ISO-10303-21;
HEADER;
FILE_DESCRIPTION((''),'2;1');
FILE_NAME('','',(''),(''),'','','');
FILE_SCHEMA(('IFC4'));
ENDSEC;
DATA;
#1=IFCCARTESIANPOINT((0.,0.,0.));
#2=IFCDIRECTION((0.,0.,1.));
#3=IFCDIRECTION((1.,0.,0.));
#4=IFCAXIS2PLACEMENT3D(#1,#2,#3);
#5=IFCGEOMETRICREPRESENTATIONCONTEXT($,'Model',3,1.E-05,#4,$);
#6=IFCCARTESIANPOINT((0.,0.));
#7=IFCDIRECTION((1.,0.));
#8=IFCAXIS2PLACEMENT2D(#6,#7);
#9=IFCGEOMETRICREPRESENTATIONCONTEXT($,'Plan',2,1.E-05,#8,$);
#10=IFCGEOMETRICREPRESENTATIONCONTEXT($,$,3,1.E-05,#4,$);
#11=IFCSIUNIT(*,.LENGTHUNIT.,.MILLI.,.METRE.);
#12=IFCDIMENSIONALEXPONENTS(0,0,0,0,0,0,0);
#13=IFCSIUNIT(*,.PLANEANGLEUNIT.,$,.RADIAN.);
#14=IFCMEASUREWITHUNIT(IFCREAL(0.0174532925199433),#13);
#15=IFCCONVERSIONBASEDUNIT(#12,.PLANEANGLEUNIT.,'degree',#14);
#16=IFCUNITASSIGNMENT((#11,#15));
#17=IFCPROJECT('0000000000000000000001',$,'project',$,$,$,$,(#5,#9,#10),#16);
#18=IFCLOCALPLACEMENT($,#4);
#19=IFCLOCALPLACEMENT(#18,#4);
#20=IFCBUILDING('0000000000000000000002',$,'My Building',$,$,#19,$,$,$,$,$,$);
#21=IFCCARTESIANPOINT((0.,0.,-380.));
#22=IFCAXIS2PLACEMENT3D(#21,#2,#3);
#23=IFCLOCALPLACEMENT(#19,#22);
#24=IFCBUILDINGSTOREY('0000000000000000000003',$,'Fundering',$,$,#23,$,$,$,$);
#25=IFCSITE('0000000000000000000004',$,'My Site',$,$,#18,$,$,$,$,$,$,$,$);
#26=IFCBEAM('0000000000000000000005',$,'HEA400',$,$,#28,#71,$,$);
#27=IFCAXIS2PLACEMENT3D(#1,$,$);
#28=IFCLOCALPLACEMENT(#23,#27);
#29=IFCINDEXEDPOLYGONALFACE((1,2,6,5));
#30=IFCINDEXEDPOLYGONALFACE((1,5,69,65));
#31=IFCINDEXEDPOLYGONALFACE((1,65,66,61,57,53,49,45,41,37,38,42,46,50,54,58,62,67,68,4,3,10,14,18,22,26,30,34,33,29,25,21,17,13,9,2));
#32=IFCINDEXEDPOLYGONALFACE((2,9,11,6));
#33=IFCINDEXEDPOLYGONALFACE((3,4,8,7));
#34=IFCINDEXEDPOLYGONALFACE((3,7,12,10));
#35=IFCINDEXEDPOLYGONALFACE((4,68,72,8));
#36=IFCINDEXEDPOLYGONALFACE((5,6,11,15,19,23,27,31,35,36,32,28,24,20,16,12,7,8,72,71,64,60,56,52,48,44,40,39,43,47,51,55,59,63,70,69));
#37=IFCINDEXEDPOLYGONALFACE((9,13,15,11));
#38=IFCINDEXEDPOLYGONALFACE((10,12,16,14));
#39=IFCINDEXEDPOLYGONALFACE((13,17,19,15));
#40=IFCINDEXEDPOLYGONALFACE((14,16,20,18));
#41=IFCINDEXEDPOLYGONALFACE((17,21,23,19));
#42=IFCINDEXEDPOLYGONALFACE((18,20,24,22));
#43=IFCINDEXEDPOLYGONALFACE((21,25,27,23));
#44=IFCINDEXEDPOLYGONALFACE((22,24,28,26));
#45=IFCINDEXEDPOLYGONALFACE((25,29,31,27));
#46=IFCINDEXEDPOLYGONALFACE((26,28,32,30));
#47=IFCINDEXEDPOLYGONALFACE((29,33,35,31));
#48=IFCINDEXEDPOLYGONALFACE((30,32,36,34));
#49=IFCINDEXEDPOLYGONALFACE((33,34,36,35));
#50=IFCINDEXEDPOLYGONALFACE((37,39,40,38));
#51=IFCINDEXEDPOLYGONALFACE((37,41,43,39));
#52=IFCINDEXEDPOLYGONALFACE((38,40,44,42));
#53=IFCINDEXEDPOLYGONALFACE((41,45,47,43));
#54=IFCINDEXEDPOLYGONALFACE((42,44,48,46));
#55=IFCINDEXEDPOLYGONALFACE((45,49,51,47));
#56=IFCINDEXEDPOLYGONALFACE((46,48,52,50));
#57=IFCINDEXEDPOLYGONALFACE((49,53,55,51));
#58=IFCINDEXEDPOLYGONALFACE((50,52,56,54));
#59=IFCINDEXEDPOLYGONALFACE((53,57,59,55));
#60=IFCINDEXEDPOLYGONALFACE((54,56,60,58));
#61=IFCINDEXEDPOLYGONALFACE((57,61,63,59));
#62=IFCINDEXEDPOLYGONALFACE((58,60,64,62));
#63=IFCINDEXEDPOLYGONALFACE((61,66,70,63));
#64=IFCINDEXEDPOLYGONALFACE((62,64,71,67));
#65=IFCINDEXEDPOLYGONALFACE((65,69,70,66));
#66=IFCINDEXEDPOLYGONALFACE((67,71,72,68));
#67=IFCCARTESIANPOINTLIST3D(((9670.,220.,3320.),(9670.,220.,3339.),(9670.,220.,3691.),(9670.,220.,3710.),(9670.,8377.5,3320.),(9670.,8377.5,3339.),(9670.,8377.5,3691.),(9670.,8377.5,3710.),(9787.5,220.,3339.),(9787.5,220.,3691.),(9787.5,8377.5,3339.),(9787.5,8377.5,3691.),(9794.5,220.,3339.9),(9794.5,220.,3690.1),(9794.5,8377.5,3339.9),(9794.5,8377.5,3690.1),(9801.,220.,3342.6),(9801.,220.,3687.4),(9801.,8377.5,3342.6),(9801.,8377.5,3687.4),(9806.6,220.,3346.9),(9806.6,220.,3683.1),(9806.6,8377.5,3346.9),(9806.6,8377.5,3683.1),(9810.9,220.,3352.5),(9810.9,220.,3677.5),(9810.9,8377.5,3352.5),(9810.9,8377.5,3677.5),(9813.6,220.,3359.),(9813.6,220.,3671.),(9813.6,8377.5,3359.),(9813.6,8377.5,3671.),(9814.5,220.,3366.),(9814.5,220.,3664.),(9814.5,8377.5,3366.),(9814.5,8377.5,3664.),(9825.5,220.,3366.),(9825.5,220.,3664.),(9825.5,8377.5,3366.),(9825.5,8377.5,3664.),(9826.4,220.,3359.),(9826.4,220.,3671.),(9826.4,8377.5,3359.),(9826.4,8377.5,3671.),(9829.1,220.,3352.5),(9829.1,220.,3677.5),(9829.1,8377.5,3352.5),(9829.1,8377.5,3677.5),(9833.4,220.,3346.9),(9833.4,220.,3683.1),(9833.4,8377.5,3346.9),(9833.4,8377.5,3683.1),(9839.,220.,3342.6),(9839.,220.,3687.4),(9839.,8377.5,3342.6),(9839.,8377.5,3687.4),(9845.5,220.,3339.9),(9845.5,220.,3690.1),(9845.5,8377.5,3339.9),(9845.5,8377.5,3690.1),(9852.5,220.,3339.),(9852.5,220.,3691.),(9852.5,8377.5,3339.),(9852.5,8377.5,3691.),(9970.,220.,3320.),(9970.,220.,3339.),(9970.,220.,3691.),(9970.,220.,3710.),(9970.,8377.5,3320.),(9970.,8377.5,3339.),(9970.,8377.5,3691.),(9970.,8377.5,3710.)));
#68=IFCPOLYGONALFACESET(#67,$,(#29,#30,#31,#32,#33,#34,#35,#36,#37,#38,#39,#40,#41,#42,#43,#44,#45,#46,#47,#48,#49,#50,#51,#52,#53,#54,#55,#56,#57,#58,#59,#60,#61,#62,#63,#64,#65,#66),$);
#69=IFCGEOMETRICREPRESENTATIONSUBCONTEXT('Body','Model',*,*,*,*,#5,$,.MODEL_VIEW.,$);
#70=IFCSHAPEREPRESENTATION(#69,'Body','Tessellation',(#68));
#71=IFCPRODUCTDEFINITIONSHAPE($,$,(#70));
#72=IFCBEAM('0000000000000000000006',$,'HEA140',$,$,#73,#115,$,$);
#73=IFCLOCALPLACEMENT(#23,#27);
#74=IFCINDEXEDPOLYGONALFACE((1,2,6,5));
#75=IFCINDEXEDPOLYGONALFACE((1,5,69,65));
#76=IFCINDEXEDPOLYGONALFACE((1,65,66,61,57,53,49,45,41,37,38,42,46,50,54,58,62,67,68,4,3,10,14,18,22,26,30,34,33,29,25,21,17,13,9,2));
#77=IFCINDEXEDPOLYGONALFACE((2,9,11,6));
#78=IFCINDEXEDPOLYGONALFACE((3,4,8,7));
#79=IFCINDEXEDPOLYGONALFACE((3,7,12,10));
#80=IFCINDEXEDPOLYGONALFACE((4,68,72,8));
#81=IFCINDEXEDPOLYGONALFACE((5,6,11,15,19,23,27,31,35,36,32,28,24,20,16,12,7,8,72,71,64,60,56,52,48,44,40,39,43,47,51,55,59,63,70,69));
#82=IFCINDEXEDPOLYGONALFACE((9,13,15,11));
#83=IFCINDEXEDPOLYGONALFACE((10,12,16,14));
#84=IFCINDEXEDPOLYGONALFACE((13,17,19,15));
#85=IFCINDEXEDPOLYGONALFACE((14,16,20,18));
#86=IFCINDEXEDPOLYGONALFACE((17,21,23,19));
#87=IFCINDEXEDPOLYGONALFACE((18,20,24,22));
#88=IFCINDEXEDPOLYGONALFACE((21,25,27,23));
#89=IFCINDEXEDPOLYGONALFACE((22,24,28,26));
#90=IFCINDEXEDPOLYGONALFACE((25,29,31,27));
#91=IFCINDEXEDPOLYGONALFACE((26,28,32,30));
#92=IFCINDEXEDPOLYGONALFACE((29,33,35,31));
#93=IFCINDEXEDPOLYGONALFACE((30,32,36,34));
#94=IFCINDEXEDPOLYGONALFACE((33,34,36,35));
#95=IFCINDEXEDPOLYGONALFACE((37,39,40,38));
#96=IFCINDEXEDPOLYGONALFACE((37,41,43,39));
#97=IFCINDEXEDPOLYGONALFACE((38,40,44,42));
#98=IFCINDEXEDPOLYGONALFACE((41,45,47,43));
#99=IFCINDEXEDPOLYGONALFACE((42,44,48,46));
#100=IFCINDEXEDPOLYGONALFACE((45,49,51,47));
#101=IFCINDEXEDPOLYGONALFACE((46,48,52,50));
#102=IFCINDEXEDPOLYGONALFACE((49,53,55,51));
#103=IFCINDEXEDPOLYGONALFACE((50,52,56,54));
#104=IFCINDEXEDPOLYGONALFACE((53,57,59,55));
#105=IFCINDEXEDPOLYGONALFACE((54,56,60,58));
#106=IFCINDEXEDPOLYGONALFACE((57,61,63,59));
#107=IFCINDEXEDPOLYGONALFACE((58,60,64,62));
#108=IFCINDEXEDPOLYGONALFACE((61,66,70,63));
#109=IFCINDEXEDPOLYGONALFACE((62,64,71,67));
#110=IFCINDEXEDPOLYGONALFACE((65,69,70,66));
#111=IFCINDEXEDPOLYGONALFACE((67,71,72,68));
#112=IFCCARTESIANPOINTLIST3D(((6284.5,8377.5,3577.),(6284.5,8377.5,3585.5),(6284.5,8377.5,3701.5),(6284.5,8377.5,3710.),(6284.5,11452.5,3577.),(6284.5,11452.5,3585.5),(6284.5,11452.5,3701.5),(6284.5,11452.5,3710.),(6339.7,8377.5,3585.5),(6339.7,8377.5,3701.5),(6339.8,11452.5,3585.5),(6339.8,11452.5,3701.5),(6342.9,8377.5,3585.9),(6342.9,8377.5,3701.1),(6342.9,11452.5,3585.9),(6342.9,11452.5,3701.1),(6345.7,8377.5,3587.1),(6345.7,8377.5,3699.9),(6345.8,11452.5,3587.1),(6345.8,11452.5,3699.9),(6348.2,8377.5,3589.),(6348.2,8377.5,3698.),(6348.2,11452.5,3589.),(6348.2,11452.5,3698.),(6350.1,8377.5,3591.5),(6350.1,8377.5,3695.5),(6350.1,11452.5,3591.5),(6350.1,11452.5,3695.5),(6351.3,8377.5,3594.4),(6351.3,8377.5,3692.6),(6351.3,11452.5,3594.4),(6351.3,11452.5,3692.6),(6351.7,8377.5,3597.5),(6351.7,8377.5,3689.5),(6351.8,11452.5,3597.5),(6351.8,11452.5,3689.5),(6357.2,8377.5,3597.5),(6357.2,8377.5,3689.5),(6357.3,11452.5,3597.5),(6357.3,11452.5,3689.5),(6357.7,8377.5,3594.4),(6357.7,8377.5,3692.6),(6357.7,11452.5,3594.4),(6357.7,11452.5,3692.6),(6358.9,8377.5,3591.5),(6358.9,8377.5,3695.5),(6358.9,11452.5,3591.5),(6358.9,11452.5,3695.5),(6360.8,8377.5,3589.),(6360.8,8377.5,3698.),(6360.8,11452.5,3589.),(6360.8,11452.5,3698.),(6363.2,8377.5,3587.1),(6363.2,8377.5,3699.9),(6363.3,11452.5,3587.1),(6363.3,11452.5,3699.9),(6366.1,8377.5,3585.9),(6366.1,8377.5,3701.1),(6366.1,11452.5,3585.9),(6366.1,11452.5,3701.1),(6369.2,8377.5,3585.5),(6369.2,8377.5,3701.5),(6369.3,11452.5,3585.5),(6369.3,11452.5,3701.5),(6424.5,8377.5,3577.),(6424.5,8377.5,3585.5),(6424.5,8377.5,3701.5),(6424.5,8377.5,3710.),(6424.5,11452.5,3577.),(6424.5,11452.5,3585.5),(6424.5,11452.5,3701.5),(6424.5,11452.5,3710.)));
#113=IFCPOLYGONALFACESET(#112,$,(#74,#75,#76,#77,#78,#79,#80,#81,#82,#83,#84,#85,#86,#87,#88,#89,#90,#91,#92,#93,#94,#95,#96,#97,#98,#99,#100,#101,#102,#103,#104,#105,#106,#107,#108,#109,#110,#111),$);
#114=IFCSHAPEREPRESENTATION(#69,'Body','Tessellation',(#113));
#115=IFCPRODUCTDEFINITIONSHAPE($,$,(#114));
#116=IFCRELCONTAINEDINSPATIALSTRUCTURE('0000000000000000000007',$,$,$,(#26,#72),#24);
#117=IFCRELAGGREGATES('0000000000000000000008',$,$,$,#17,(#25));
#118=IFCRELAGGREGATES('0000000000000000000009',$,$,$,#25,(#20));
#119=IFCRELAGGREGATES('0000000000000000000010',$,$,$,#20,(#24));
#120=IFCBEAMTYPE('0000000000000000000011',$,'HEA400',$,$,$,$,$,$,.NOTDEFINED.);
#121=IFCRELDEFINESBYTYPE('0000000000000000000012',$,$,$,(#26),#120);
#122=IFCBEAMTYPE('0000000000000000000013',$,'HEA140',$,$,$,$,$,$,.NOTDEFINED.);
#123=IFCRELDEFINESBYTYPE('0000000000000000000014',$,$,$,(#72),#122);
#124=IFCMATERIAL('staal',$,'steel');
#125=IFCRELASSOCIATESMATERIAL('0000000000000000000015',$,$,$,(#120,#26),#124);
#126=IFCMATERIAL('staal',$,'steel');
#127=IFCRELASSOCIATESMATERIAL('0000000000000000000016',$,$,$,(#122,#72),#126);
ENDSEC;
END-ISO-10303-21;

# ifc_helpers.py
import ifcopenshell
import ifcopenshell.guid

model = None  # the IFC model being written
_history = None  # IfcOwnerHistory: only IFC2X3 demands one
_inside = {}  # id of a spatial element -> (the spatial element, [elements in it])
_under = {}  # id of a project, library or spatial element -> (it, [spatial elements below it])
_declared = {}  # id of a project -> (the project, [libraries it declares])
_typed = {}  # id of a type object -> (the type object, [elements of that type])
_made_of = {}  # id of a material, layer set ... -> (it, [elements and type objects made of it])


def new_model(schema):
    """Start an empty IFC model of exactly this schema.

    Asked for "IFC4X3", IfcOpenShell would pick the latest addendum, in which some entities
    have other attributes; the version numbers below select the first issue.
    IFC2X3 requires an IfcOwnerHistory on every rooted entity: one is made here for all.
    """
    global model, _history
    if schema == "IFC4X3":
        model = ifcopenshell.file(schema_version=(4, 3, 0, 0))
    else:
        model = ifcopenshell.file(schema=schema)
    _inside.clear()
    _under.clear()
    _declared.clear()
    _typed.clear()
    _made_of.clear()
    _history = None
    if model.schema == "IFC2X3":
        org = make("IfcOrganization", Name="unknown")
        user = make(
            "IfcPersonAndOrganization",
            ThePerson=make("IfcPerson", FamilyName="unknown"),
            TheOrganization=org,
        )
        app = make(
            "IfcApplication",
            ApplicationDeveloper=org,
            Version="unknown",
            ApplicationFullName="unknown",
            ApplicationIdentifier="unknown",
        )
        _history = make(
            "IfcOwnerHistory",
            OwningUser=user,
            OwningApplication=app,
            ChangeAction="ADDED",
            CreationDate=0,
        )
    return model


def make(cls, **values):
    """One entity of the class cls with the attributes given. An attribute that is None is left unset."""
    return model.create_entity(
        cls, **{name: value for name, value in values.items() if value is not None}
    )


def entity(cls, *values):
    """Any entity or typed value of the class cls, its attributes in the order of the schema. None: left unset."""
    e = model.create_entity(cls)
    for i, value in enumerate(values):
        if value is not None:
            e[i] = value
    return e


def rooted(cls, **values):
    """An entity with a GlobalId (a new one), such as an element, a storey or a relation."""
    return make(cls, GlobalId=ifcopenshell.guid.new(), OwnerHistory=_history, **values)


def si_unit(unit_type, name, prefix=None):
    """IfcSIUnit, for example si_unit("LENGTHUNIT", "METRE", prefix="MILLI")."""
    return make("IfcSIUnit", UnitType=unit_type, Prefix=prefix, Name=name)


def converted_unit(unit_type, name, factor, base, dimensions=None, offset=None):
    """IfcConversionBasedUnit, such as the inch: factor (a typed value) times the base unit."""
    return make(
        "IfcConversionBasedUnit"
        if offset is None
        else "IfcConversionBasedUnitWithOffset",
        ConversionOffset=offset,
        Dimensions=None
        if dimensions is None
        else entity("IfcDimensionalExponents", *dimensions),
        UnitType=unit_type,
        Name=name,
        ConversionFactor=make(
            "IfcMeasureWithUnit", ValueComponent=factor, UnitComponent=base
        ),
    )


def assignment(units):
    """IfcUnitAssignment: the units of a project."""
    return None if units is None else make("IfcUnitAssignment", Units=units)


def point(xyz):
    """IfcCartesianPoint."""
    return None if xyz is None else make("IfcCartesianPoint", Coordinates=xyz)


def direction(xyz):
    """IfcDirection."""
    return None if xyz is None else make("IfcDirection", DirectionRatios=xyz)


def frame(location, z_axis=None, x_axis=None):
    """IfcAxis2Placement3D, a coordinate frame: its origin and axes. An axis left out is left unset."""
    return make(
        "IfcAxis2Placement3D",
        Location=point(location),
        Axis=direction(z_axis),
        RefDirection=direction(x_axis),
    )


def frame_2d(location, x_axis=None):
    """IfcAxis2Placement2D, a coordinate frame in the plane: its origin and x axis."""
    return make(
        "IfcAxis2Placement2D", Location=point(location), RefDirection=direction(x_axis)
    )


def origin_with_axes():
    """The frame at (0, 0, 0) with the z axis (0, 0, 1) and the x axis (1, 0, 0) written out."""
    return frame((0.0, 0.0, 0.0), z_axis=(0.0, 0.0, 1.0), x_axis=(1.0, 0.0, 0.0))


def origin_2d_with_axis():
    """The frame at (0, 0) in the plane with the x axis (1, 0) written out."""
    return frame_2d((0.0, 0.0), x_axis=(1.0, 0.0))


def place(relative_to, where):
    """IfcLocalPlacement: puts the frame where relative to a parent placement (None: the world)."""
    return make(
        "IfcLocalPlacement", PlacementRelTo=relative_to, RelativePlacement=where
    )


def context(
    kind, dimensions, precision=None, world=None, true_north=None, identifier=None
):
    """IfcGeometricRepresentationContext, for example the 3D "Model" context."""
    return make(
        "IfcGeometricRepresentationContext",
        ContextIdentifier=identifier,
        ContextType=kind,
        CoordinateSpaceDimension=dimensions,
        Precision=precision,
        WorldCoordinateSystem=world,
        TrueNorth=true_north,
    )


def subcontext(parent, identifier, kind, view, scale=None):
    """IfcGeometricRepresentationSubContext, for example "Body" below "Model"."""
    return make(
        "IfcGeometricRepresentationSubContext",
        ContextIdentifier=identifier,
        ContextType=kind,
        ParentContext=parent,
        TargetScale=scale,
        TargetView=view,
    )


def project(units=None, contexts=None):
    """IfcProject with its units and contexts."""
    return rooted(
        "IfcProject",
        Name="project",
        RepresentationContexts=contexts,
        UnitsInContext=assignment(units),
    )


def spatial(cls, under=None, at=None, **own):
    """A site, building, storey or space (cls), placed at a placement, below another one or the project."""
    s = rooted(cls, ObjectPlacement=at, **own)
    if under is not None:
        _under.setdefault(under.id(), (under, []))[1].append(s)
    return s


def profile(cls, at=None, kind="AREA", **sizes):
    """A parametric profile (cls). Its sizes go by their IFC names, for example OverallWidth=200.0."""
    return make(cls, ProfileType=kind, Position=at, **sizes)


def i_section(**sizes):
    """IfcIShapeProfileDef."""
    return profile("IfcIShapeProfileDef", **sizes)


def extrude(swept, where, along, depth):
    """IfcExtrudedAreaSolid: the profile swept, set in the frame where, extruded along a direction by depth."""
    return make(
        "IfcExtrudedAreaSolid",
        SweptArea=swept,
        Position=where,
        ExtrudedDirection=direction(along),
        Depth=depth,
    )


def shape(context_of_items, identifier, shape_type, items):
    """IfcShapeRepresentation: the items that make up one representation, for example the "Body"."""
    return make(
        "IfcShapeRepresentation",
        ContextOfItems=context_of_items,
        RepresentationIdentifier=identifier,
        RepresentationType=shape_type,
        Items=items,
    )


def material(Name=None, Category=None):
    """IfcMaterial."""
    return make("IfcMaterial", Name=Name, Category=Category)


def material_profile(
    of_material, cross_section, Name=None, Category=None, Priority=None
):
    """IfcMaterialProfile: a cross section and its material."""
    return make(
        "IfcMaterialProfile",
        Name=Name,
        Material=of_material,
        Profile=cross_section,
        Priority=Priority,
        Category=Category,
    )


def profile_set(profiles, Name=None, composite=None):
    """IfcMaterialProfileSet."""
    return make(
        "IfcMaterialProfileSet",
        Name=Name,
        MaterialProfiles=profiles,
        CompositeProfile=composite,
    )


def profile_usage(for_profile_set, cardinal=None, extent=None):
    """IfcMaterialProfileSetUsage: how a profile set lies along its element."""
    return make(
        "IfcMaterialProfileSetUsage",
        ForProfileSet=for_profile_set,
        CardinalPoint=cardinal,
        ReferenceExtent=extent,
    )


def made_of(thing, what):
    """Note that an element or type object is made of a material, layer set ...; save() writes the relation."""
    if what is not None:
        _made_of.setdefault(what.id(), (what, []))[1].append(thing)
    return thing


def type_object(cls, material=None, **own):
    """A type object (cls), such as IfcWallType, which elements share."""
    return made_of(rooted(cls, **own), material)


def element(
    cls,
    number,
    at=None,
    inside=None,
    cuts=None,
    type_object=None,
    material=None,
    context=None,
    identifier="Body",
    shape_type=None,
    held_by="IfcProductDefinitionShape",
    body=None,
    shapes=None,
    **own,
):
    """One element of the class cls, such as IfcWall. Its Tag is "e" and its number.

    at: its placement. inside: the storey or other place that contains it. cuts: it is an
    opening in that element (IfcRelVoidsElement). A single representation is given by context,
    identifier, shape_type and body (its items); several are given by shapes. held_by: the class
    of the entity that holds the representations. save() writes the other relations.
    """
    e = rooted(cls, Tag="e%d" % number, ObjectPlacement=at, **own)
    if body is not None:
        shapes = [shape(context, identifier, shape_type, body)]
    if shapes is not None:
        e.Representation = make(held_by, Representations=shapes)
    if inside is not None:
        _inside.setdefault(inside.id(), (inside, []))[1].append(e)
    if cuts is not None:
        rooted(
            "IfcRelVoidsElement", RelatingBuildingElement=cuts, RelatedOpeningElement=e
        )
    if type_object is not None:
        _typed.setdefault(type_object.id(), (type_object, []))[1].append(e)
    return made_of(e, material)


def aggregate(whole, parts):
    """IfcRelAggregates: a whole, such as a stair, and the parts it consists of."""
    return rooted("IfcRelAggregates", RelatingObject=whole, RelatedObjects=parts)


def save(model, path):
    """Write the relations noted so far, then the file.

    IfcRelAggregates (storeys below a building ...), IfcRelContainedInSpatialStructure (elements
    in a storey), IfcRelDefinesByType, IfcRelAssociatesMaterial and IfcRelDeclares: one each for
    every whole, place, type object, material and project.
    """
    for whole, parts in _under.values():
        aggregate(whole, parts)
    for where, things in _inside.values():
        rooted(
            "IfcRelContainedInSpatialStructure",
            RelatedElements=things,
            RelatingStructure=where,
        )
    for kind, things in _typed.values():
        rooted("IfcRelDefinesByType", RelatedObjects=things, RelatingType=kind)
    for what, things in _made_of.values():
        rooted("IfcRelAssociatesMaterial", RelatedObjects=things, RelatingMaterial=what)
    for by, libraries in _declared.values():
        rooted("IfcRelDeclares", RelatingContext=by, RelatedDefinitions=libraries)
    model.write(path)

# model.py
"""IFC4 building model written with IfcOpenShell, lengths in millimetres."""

from ifc_helpers import new_model, entity, si_unit, converted_unit, frame, origin_with_axes, origin_2d_with_axis, place, context, subcontext, project, spatial, i_section, extrude, material, material_profile, profile_set, profile_usage, type_object, element, save


model = new_model("IFC4")

# Units and contexts
model_context = context("Model", 3, precision=1e-05, world=origin_with_axes())
plan_context = context("Plan", 2, precision=1e-05, world=origin_2d_with_axis())
context_of_model = context(None, 3, precision=1e-05, world=origin_with_axes())
body_context = subcontext(model_context, "Body", "Model", "MODEL_VIEW")
ifc_project = project(units=[si_unit("LENGTHUNIT", "METRE", prefix="MILLI"), converted_unit("PLANEANGLEUNIT", "degree", entity("IfcReal", 0.0174532925199433), si_unit("PLANEANGLEUNIT", "RADIAN"), dimensions=[0, 0, 0, 0, 0, 0, 0])], contexts=[model_context, plan_context, context_of_model])

# Site, building, storey
site_placement = place(None, origin_with_axes())
site = spatial("IfcSite", under=ifc_project, at=site_placement, Name="My Site")
building_placement = place(site_placement, origin_with_axes())
building = spatial("IfcBuilding", under=site, at=building_placement, Name="My Building")
storey_placement = place(building_placement, frame((0.0, 0.0, -380.0), z_axis=(0.0, 0.0, 1.0), x_axis=(1.0, 0.0, 0.0)))
storey = spatial("IfcBuildingStorey", under=building, at=storey_placement, Name="Fundering")

# Shared definitions
ifc_material_1 = material(Name="staal", Category="steel")

# Beams
ifc_material_profile_1 = material_profile(ifc_material_1, i_section(OverallWidth=300.0, OverallDepth=390.0, WebThickness=11.0, FlangeThickness=19.0, FilletRadius=27.0))
ifc_profile_set_1 = profile_set([ifc_material_profile_1], Name="HEA400")
ifc_profile_usage_1 = profile_usage(ifc_profile_set_1, cardinal=5)
beam_type_1 = type_object("IfcBeamType", Name="HEA400", PredefinedType="NOTDEFINED", material=ifc_profile_set_1)
beam_1_placement = place(storey_placement, frame((9820.0, 220.0, 3515.0), z_axis=(0.0, 1.0, 0.0), x_axis=(-1.0, 0.0, 0.0)))
element("IfcBeam", 1, at=beam_1_placement, inside=storey, type_object=beam_type_1, material=ifc_profile_usage_1, Name="HEA400", context=body_context, shape_type="SweptSolid", body=[
    extrude(i_section(OverallWidth=300.0, OverallDepth=390.0, WebThickness=11.0, FlangeThickness=19.0, FilletRadius=27.0), origin_with_axes(), (0.0, 0.0, 1.0), 8157.5),
])
ifc_material_2 = material(Name="staal", Category="steel")
ifc_material_profile_2 = material_profile(ifc_material_2, i_section(OverallWidth=140.0, OverallDepth=133.0, WebThickness=5.5, FlangeThickness=8.5, FilletRadius=12.0))
ifc_profile_set_2 = profile_set([ifc_material_profile_2], Name="HEA140")
ifc_profile_usage_2 = profile_usage(ifc_profile_set_2)
beam_type_2 = type_object("IfcBeamType", Name="HEA140", PredefinedType="NOTDEFINED", material=ifc_profile_set_2)
beam_2_placement = place(storey_placement, frame((6354.5, 8377.5, 3643.5), z_axis=(0.0, 1.0, 0.0), x_axis=(-1.0, 0.0, 0.0)))
element("IfcBeam", 2, at=beam_2_placement, inside=storey, type_object=beam_type_2, material=ifc_profile_usage_2, Name="HEA140", context=body_context, shape_type="SweptSolid", body=[
    extrude(i_section(OverallWidth=140.0, OverallDepth=133.0, WebThickness=5.5, FlangeThickness=8.5, FilletRadius=12.0), origin_with_axes(), (0.0, 0.0, 1.0), 3075.0),
])

save(model, "model.ifc")
